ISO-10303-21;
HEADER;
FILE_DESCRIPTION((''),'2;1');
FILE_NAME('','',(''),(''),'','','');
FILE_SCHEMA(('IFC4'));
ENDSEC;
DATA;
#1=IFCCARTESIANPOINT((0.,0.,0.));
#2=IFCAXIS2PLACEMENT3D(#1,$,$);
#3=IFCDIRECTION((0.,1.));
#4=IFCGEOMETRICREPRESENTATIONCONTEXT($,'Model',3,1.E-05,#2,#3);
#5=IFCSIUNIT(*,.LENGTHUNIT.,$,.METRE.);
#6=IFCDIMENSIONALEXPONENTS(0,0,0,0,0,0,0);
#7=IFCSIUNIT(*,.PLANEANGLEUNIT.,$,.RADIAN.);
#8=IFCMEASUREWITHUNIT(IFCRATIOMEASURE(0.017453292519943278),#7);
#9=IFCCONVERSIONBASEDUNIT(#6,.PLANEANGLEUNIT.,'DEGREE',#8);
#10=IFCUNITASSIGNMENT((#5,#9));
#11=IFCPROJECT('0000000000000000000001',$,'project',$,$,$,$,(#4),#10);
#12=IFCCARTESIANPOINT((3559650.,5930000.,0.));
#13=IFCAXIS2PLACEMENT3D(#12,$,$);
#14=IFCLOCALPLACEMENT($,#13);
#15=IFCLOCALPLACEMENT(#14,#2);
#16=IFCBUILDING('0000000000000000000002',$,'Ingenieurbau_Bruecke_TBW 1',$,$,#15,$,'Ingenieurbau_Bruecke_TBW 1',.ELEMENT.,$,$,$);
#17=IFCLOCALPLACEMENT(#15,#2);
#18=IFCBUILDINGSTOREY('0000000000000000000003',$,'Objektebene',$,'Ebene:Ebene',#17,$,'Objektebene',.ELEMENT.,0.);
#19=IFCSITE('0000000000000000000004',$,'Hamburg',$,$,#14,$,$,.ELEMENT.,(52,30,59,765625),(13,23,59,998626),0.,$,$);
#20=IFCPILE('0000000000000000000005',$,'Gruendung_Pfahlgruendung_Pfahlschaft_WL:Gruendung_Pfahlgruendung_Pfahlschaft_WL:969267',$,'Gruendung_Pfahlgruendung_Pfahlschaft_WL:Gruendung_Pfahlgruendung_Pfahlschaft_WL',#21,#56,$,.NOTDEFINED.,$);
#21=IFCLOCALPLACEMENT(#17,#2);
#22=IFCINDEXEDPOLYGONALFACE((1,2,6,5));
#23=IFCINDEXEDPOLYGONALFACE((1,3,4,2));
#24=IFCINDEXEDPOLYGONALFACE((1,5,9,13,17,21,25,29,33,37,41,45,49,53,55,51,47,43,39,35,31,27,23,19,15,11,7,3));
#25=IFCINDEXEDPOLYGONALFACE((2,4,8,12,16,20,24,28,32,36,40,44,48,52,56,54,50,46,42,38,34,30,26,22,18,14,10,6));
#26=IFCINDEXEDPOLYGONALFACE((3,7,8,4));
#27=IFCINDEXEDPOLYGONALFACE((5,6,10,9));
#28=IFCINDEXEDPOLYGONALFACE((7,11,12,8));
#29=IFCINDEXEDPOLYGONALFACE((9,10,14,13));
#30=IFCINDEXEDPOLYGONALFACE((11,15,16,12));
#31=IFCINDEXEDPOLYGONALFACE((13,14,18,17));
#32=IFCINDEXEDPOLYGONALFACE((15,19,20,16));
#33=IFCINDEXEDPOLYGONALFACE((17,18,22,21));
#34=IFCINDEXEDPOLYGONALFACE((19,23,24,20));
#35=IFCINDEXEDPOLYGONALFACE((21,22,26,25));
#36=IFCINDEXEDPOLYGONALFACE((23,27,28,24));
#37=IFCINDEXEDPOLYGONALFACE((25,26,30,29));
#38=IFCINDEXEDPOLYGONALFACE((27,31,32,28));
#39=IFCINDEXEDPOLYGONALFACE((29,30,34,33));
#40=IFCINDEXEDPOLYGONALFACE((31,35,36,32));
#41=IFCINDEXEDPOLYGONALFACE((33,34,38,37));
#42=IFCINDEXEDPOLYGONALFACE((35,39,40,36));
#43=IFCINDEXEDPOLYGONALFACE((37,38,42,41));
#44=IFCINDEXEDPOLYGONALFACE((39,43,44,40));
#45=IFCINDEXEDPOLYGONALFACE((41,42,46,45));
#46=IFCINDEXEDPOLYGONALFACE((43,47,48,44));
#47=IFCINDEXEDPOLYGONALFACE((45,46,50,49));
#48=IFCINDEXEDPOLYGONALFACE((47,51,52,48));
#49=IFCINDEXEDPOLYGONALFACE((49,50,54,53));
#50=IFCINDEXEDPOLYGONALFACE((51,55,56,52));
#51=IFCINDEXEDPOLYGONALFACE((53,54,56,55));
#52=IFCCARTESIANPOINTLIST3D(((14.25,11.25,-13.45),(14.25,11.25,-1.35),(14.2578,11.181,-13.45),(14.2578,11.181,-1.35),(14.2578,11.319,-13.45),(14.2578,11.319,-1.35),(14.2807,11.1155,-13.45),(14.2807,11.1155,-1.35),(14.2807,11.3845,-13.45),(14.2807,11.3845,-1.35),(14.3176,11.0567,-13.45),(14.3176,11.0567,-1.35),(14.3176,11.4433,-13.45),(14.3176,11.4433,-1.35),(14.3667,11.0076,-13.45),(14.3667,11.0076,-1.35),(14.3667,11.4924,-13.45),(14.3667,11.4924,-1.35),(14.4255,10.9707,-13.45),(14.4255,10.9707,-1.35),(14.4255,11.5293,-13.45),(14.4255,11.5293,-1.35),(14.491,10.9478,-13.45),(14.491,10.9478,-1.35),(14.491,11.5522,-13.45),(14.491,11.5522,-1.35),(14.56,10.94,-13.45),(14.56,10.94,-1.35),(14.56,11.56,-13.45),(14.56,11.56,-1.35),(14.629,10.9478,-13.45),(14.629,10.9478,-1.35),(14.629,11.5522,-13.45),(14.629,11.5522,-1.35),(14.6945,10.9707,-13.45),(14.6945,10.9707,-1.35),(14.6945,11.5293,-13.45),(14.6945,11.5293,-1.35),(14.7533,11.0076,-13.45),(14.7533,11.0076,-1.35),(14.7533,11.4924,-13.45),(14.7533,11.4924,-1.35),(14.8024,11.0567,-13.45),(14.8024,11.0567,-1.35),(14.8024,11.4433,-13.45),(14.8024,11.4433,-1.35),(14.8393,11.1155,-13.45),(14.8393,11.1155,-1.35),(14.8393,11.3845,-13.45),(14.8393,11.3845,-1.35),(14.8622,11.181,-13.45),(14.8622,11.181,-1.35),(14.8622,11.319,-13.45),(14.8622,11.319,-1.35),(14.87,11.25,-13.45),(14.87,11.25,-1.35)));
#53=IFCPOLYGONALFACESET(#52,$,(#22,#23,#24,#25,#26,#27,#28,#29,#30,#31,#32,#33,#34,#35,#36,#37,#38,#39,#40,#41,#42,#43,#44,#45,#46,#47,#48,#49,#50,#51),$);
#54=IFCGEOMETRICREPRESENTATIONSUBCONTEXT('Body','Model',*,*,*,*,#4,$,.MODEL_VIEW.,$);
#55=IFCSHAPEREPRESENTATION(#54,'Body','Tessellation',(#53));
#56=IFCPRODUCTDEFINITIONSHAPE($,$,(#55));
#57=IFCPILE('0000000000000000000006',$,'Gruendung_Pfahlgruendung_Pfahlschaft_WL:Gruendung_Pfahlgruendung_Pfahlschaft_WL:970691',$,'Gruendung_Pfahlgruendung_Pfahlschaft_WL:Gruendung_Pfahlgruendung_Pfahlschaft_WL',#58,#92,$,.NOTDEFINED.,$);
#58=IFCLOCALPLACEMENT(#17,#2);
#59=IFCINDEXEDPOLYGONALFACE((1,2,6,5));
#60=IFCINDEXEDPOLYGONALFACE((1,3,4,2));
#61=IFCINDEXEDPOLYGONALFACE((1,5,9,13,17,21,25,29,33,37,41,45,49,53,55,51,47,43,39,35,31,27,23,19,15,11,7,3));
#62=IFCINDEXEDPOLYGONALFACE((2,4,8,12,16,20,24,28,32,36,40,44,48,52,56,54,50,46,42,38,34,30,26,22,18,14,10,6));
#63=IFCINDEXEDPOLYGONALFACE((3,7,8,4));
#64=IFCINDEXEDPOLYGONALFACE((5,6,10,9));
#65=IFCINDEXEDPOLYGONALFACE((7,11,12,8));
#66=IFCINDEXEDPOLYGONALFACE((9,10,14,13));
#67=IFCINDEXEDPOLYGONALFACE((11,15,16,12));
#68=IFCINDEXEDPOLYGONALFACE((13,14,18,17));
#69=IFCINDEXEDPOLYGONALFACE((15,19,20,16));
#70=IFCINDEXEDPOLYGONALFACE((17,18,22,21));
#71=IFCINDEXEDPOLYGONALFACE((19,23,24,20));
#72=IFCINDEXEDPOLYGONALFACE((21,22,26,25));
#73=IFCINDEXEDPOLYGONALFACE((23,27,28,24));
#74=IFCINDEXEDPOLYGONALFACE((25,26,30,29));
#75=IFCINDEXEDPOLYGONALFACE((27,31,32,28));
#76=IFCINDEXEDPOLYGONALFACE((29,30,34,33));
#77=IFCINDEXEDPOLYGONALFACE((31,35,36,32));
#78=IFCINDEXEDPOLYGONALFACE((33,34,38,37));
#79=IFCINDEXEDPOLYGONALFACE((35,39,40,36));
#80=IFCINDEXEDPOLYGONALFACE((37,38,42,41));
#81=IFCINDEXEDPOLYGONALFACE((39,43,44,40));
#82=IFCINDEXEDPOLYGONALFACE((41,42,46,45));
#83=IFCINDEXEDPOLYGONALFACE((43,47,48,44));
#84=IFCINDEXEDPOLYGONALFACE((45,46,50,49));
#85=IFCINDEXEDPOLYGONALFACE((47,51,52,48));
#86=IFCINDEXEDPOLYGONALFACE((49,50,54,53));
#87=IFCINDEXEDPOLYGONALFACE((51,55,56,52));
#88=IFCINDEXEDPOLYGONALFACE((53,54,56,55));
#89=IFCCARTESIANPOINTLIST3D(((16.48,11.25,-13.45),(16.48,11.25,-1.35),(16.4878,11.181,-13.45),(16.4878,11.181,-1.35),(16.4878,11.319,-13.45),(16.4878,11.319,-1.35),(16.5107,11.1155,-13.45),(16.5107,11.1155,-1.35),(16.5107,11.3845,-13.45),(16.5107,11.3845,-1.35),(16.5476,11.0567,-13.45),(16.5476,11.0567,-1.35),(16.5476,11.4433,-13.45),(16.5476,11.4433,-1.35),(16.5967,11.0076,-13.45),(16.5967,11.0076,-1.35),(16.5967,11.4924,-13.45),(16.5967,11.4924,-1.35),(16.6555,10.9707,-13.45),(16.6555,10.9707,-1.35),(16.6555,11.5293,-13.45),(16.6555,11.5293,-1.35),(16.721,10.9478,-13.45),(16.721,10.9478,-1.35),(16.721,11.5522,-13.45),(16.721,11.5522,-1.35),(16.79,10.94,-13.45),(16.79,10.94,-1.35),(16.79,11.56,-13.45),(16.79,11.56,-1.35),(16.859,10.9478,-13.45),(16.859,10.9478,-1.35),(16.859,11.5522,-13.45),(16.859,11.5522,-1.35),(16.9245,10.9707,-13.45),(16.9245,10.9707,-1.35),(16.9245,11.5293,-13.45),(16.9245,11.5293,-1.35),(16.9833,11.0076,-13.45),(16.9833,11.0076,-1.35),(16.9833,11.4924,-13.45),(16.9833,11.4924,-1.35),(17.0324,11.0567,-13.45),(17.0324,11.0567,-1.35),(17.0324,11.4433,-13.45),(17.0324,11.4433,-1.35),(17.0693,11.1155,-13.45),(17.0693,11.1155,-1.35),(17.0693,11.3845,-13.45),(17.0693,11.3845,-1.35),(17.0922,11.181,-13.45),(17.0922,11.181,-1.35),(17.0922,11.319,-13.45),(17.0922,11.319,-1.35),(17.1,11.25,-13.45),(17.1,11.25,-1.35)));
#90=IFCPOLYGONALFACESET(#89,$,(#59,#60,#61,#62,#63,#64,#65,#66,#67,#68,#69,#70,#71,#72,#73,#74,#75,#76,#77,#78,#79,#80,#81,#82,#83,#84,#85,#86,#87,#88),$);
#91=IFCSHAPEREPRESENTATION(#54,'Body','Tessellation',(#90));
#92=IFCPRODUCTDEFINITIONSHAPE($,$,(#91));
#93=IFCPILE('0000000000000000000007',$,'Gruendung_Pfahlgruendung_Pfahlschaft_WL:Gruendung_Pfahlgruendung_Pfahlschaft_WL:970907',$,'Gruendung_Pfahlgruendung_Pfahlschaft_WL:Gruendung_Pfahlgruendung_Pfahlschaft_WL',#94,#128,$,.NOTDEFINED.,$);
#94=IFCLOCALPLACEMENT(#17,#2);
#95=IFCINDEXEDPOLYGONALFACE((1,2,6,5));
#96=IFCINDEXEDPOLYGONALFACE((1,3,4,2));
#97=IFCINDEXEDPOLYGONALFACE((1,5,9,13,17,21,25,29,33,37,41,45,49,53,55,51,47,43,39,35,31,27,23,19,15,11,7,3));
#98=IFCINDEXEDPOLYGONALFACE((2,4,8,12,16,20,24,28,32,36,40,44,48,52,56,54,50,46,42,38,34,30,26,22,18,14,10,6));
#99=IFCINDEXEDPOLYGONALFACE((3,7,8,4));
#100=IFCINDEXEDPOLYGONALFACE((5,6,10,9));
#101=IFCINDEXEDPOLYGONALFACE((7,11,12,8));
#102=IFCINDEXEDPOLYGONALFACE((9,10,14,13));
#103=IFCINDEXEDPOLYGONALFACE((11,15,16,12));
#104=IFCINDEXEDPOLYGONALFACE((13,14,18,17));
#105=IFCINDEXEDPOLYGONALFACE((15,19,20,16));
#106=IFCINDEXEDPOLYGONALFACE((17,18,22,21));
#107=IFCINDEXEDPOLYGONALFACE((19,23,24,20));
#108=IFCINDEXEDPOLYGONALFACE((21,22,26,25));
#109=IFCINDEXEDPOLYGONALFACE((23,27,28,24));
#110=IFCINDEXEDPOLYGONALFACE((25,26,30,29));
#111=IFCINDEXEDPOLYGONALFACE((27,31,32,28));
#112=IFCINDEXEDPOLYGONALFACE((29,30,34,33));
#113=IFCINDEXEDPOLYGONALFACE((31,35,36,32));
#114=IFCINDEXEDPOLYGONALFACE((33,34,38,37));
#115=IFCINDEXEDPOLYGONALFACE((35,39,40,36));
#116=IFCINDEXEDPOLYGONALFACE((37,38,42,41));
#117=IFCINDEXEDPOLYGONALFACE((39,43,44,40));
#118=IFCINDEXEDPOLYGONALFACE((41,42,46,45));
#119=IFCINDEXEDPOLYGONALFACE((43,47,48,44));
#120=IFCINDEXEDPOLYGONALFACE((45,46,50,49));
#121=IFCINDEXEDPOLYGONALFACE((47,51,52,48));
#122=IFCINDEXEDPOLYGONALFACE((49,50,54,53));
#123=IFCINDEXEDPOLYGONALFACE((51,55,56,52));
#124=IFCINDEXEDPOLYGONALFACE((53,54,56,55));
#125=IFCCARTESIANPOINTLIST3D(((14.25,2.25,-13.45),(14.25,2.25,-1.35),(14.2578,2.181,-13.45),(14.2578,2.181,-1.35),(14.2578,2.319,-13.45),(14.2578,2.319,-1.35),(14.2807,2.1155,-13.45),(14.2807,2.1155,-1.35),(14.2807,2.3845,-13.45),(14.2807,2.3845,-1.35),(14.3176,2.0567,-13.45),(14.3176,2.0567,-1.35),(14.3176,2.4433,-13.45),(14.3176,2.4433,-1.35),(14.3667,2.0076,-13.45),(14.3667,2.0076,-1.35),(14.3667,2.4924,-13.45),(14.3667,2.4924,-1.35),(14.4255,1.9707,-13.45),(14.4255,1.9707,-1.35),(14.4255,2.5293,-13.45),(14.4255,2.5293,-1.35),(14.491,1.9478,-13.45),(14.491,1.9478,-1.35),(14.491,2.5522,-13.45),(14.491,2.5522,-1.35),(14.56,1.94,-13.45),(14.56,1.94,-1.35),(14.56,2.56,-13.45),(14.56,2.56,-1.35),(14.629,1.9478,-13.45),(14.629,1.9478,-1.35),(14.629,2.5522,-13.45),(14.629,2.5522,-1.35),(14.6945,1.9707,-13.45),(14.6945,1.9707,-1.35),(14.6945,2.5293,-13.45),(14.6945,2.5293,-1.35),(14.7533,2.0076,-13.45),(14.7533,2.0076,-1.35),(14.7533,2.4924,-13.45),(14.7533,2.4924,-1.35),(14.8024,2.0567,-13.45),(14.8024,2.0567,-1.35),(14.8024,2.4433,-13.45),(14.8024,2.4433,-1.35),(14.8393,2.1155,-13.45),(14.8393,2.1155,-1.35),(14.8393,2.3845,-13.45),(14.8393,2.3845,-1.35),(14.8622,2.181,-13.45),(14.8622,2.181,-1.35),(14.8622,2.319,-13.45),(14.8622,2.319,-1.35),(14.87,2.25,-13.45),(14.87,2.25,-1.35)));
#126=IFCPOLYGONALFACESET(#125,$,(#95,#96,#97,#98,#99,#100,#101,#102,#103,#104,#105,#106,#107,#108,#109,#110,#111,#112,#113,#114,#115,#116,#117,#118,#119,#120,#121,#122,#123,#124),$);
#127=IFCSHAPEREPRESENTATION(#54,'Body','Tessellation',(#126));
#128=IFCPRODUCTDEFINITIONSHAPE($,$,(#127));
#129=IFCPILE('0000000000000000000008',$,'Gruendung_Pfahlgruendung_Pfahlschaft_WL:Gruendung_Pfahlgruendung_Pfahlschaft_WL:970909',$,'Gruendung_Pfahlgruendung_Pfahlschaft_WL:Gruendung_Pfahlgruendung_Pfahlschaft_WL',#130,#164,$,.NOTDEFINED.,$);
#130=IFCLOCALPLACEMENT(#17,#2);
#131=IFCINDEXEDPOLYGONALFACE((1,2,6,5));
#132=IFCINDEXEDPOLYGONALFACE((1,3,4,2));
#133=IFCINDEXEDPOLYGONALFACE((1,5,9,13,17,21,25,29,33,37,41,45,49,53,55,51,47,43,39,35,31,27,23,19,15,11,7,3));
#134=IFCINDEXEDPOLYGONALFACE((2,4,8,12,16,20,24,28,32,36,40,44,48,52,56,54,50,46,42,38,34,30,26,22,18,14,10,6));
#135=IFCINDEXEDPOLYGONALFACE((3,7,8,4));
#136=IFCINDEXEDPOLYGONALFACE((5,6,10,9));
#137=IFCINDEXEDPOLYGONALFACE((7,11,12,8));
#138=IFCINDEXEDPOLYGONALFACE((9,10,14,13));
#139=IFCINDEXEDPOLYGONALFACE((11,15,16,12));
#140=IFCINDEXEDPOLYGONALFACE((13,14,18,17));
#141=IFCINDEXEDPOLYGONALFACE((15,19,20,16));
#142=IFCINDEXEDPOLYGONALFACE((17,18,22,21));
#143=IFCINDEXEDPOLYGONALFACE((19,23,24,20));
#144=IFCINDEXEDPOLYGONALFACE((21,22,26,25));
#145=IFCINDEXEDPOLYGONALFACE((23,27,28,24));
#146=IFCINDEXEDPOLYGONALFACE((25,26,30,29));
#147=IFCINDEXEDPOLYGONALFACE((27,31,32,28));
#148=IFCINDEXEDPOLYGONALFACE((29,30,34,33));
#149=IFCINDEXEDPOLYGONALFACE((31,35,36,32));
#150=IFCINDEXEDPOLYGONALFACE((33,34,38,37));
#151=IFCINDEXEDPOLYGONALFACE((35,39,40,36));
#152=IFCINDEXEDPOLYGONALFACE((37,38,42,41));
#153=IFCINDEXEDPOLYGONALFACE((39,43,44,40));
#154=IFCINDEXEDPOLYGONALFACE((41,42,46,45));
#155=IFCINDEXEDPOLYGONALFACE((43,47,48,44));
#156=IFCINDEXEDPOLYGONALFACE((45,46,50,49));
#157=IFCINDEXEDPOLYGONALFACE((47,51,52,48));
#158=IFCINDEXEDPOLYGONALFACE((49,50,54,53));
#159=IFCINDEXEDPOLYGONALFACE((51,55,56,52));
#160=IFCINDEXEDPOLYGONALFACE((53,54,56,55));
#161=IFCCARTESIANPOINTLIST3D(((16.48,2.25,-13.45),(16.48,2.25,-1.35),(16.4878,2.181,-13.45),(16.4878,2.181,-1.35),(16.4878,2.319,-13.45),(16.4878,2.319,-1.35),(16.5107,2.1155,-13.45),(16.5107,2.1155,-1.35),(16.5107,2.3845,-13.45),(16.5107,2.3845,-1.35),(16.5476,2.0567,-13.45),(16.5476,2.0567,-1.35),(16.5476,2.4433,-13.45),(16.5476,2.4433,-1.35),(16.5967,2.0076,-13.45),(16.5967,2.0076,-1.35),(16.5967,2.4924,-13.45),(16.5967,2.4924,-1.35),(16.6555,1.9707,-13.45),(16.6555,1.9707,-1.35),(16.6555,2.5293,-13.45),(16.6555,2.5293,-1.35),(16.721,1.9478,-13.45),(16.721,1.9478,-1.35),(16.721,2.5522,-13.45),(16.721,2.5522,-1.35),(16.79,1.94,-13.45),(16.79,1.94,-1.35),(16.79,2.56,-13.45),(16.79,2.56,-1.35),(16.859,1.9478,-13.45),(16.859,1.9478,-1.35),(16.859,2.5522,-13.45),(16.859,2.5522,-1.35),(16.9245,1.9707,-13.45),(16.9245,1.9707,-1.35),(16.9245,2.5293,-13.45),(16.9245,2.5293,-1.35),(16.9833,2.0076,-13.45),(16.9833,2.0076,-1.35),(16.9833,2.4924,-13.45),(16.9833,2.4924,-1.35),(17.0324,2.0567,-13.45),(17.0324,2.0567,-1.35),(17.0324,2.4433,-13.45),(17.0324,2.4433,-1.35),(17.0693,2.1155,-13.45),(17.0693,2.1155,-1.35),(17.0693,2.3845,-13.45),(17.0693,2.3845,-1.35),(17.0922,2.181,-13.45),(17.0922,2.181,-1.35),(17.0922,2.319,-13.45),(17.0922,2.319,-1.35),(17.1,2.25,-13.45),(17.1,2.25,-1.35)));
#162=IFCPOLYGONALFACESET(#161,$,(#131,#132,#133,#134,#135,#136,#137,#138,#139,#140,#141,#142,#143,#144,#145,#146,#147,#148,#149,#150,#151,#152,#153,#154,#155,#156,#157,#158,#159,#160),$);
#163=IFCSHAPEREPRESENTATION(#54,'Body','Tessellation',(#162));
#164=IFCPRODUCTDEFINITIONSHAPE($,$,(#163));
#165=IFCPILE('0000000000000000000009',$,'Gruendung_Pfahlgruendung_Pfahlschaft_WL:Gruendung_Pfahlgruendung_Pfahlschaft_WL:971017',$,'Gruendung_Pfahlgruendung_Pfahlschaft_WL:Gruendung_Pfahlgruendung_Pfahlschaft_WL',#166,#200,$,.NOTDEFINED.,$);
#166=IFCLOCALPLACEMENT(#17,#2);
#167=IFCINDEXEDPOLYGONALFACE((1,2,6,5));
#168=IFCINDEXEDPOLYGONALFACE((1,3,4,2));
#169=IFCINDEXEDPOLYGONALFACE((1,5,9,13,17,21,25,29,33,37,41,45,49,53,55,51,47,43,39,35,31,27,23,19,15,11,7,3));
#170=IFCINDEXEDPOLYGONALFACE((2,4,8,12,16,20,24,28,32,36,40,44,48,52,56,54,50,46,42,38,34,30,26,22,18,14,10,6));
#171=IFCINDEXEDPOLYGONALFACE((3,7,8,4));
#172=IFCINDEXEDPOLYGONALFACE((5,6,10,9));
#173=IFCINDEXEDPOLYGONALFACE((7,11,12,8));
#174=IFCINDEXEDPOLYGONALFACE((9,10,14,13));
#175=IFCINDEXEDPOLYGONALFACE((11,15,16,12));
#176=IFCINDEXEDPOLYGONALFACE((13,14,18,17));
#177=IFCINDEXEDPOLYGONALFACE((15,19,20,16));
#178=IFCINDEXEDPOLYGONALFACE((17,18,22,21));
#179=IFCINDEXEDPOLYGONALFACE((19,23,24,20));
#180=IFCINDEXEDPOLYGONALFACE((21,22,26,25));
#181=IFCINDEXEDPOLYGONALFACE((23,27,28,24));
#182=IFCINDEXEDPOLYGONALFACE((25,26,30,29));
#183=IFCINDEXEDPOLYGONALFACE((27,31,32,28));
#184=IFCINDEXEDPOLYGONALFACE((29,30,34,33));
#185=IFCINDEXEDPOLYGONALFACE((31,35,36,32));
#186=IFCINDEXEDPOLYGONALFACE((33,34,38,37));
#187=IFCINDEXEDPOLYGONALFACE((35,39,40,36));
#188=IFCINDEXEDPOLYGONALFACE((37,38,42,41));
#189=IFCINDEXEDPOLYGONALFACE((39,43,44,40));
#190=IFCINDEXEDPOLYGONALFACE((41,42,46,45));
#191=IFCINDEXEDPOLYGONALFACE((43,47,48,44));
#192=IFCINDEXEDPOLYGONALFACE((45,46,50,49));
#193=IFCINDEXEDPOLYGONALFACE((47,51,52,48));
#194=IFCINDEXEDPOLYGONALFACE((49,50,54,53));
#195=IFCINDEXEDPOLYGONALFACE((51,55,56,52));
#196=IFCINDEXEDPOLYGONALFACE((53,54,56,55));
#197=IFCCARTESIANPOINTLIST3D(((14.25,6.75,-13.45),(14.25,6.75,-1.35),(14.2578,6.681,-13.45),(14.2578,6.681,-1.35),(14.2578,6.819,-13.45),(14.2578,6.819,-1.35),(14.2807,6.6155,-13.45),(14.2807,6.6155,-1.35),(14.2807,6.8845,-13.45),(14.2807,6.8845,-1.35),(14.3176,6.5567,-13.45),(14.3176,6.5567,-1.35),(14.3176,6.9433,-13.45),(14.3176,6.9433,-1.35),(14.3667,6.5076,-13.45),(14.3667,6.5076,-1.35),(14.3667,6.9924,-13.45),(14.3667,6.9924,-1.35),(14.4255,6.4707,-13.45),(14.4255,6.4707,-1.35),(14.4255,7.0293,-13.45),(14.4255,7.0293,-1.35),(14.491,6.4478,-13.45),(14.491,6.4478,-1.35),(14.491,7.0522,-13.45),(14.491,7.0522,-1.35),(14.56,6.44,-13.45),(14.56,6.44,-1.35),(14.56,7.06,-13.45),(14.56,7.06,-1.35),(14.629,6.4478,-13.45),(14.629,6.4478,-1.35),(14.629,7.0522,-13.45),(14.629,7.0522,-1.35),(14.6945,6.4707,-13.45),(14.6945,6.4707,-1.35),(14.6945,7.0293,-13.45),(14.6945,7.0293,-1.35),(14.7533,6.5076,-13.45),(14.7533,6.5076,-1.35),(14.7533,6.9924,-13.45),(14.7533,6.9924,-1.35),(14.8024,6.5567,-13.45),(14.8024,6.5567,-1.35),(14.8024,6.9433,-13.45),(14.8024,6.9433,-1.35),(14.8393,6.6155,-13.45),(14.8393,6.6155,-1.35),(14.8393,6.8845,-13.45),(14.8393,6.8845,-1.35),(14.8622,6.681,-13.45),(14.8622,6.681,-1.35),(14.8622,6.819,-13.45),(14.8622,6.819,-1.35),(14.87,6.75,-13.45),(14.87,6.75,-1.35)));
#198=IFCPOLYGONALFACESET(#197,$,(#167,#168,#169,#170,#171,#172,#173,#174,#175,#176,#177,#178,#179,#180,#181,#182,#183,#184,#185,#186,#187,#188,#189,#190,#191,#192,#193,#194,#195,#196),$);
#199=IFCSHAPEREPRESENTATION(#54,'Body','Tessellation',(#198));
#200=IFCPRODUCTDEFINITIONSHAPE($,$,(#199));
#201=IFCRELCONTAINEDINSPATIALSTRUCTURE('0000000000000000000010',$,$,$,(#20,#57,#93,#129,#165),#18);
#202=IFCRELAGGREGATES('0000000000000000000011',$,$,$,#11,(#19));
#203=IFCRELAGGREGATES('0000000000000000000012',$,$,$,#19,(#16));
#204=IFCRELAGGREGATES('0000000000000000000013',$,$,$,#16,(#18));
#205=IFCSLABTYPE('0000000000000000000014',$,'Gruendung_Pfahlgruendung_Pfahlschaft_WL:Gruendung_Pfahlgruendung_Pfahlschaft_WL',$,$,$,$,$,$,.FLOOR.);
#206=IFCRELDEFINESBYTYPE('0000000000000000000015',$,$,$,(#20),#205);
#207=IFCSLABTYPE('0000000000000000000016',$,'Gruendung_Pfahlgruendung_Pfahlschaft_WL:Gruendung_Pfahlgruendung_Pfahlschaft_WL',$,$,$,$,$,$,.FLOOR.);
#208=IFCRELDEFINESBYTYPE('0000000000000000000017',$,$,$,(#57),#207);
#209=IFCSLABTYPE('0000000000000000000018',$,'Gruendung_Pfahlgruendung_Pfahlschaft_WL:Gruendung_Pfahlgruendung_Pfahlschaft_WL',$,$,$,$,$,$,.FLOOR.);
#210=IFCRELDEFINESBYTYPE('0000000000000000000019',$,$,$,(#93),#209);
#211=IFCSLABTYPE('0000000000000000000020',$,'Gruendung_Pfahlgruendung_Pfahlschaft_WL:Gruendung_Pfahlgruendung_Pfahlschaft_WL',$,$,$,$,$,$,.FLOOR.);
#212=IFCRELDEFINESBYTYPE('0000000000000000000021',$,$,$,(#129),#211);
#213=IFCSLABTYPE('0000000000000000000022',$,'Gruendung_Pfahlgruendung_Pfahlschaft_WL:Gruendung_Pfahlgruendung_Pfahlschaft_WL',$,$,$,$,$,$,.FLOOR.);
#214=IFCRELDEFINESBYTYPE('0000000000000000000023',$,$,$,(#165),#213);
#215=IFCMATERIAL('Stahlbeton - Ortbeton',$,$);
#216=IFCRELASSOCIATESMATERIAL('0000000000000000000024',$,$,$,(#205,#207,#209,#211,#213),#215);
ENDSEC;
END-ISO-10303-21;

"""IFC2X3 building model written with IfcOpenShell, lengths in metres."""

from ifc_helpers import new_model, entity, si_unit, converted_unit, direction, frame, frame_2d, origin, origin_2d_with_axis, place, context, subcontext, project, spatial, circle, extrude, material, type_object, element, save


model = new_model("IFC2X3")

# Units and contexts
model_context = context("Model", 3, precision=1e-05, world=origin(), true_north=direction((0.0, 1.0)))
body_context = subcontext(model_context, "Body", "Model", "MODEL_VIEW")
ifc_project = project(units=[si_unit("LENGTHUNIT", "METRE"), converted_unit("PLANEANGLEUNIT", "DEGREE", entity("IfcRatioMeasure", 0.017453292519943278), si_unit("PLANEANGLEUNIT", "RADIAN"), dimensions=[0, 0, 0, 0, 0, 0, 0])], contexts=[model_context])

# Site, building, storey
site_placement = place(None, frame((3559650.0, 5930000.0, 0.0)))
site = spatial("IfcSite", under=ifc_project, at=site_placement, Name="Hamburg", CompositionType="ELEMENT", RefLatitude=(52, 30, 59, 765625), RefLongitude=(13, 23, 59, 998626), RefElevation=0.0)
building_placement = place(site_placement, origin())
building = spatial("IfcBuilding", under=site, at=building_placement, Name="Ingenieurbau_Bruecke_TBW 1", LongName="Ingenieurbau_Bruecke_TBW 1", CompositionType="ELEMENT")
storey_placement = place(building_placement, origin())
storey = spatial("IfcBuildingStorey", under=building, at=storey_placement, Name="Objektebene", ObjectType="Ebene:Ebene", LongName="Objektebene", CompositionType="ELEMENT", Elevation=0.0)

# Piles
ifc_material_1 = material(Name="Stahlbeton - Ortbeton")
slab_type_1 = type_object("IfcSlabType", Name="Gruendung_Pfahlgruendung_Pfahlschaft_WL:Gruendung_Pfahlgruendung_Pfahlschaft_WL", PredefinedType="FLOOR", material=ifc_material_1)
pile_1_placement = place(storey_placement, origin())
element("IfcPile", 1, at=pile_1_placement, inside=storey, type_object=slab_type_1, Name="Gruendung_Pfahlgruendung_Pfahlschaft_WL:Gruendung_Pfahlgruendung_Pfahlschaft_WL:969267", ObjectType="Gruendung_Pfahlgruendung_Pfahlschaft_WL:Gruendung_Pfahlgruendung_Pfahlschaft_WL", PredefinedType="NOTDEFINED", context=body_context, shape_type="SweptSolid", body=[
    extrude(circle(Radius=0.31, at=origin_2d_with_axis()), frame((14.56, 11.25, -13.45)), (0.0, 0.0, 1.0), 12.1),
])
slab_type_2 = type_object("IfcSlabType", Name="Gruendung_Pfahlgruendung_Pfahlschaft_WL:Gruendung_Pfahlgruendung_Pfahlschaft_WL", PredefinedType="FLOOR", material=ifc_material_1)
pile_2_placement = place(storey_placement, origin())
element("IfcPile", 2, at=pile_2_placement, inside=storey, type_object=slab_type_2, Name="Gruendung_Pfahlgruendung_Pfahlschaft_WL:Gruendung_Pfahlgruendung_Pfahlschaft_WL:970691", ObjectType="Gruendung_Pfahlgruendung_Pfahlschaft_WL:Gruendung_Pfahlgruendung_Pfahlschaft_WL", PredefinedType="NOTDEFINED", context=body_context, shape_type="SweptSolid", body=[
    extrude(circle(Radius=0.31, at=origin_2d_with_axis()), frame((16.79, 11.25, -13.45), z_axis=(0.0, 0.0, 1.0), x_axis=(-1.0, 0.0, 0.0)), (0.0, 0.0, 1.0), 12.1),
])
slab_type_3 = type_object("IfcSlabType", Name="Gruendung_Pfahlgruendung_Pfahlschaft_WL:Gruendung_Pfahlgruendung_Pfahlschaft_WL", PredefinedType="FLOOR", material=ifc_material_1)
pile_3_placement = place(storey_placement, origin())
element("IfcPile", 3, at=pile_3_placement, inside=storey, type_object=slab_type_3, Name="Gruendung_Pfahlgruendung_Pfahlschaft_WL:Gruendung_Pfahlgruendung_Pfahlschaft_WL:970907", ObjectType="Gruendung_Pfahlgruendung_Pfahlschaft_WL:Gruendung_Pfahlgruendung_Pfahlschaft_WL", PredefinedType="NOTDEFINED", context=body_context, shape_type="SweptSolid", body=[
    extrude(circle(Radius=0.31, at=frame_2d((0.0, 0.0), x_axis=(1.0, 0.0))), frame((14.56, 2.25, -13.45)), (0.0, 0.0, 1.0), 12.1),
])
slab_type_4 = type_object("IfcSlabType", Name="Gruendung_Pfahlgruendung_Pfahlschaft_WL:Gruendung_Pfahlgruendung_Pfahlschaft_WL", PredefinedType="FLOOR", material=ifc_material_1)
pile_4_placement = place(storey_placement, origin())
element("IfcPile", 4, at=pile_4_placement, inside=storey, type_object=slab_type_4, Name="Gruendung_Pfahlgruendung_Pfahlschaft_WL:Gruendung_Pfahlgruendung_Pfahlschaft_WL:970909", ObjectType="Gruendung_Pfahlgruendung_Pfahlschaft_WL:Gruendung_Pfahlgruendung_Pfahlschaft_WL", PredefinedType="NOTDEFINED", context=body_context, shape_type="SweptSolid", body=[
    extrude(circle(Radius=0.31, at=frame_2d((0.0, 0.0), x_axis=(1.0, 0.0))), frame((16.79, 2.25, -13.45), z_axis=(0.0, 0.0, 1.0), x_axis=(-1.0, 0.0, 0.0)), (0.0, 0.0, 1.0), 12.1),
])
slab_type_5 = type_object("IfcSlabType", Name="Gruendung_Pfahlgruendung_Pfahlschaft_WL:Gruendung_Pfahlgruendung_Pfahlschaft_WL", PredefinedType="FLOOR", material=ifc_material_1)
pile_5_placement = place(storey_placement, origin())
element("IfcPile", 5, at=pile_5_placement, inside=storey, type_object=slab_type_5, Name="Gruendung_Pfahlgruendung_Pfahlschaft_WL:Gruendung_Pfahlgruendung_Pfahlschaft_WL:971017", ObjectType="Gruendung_Pfahlgruendung_Pfahlschaft_WL:Gruendung_Pfahlgruendung_Pfahlschaft_WL", PredefinedType="NOTDEFINED", context=body_context, shape_type="SweptSolid", body=[
    extrude(circle(Radius=0.31, at=frame_2d((0.0, 0.0), x_axis=(1.0, 0.0))), frame((14.56, 6.75, -13.45)), (0.0, 0.0, 1.0), 12.1),
])

save(model, "model.ifc")
